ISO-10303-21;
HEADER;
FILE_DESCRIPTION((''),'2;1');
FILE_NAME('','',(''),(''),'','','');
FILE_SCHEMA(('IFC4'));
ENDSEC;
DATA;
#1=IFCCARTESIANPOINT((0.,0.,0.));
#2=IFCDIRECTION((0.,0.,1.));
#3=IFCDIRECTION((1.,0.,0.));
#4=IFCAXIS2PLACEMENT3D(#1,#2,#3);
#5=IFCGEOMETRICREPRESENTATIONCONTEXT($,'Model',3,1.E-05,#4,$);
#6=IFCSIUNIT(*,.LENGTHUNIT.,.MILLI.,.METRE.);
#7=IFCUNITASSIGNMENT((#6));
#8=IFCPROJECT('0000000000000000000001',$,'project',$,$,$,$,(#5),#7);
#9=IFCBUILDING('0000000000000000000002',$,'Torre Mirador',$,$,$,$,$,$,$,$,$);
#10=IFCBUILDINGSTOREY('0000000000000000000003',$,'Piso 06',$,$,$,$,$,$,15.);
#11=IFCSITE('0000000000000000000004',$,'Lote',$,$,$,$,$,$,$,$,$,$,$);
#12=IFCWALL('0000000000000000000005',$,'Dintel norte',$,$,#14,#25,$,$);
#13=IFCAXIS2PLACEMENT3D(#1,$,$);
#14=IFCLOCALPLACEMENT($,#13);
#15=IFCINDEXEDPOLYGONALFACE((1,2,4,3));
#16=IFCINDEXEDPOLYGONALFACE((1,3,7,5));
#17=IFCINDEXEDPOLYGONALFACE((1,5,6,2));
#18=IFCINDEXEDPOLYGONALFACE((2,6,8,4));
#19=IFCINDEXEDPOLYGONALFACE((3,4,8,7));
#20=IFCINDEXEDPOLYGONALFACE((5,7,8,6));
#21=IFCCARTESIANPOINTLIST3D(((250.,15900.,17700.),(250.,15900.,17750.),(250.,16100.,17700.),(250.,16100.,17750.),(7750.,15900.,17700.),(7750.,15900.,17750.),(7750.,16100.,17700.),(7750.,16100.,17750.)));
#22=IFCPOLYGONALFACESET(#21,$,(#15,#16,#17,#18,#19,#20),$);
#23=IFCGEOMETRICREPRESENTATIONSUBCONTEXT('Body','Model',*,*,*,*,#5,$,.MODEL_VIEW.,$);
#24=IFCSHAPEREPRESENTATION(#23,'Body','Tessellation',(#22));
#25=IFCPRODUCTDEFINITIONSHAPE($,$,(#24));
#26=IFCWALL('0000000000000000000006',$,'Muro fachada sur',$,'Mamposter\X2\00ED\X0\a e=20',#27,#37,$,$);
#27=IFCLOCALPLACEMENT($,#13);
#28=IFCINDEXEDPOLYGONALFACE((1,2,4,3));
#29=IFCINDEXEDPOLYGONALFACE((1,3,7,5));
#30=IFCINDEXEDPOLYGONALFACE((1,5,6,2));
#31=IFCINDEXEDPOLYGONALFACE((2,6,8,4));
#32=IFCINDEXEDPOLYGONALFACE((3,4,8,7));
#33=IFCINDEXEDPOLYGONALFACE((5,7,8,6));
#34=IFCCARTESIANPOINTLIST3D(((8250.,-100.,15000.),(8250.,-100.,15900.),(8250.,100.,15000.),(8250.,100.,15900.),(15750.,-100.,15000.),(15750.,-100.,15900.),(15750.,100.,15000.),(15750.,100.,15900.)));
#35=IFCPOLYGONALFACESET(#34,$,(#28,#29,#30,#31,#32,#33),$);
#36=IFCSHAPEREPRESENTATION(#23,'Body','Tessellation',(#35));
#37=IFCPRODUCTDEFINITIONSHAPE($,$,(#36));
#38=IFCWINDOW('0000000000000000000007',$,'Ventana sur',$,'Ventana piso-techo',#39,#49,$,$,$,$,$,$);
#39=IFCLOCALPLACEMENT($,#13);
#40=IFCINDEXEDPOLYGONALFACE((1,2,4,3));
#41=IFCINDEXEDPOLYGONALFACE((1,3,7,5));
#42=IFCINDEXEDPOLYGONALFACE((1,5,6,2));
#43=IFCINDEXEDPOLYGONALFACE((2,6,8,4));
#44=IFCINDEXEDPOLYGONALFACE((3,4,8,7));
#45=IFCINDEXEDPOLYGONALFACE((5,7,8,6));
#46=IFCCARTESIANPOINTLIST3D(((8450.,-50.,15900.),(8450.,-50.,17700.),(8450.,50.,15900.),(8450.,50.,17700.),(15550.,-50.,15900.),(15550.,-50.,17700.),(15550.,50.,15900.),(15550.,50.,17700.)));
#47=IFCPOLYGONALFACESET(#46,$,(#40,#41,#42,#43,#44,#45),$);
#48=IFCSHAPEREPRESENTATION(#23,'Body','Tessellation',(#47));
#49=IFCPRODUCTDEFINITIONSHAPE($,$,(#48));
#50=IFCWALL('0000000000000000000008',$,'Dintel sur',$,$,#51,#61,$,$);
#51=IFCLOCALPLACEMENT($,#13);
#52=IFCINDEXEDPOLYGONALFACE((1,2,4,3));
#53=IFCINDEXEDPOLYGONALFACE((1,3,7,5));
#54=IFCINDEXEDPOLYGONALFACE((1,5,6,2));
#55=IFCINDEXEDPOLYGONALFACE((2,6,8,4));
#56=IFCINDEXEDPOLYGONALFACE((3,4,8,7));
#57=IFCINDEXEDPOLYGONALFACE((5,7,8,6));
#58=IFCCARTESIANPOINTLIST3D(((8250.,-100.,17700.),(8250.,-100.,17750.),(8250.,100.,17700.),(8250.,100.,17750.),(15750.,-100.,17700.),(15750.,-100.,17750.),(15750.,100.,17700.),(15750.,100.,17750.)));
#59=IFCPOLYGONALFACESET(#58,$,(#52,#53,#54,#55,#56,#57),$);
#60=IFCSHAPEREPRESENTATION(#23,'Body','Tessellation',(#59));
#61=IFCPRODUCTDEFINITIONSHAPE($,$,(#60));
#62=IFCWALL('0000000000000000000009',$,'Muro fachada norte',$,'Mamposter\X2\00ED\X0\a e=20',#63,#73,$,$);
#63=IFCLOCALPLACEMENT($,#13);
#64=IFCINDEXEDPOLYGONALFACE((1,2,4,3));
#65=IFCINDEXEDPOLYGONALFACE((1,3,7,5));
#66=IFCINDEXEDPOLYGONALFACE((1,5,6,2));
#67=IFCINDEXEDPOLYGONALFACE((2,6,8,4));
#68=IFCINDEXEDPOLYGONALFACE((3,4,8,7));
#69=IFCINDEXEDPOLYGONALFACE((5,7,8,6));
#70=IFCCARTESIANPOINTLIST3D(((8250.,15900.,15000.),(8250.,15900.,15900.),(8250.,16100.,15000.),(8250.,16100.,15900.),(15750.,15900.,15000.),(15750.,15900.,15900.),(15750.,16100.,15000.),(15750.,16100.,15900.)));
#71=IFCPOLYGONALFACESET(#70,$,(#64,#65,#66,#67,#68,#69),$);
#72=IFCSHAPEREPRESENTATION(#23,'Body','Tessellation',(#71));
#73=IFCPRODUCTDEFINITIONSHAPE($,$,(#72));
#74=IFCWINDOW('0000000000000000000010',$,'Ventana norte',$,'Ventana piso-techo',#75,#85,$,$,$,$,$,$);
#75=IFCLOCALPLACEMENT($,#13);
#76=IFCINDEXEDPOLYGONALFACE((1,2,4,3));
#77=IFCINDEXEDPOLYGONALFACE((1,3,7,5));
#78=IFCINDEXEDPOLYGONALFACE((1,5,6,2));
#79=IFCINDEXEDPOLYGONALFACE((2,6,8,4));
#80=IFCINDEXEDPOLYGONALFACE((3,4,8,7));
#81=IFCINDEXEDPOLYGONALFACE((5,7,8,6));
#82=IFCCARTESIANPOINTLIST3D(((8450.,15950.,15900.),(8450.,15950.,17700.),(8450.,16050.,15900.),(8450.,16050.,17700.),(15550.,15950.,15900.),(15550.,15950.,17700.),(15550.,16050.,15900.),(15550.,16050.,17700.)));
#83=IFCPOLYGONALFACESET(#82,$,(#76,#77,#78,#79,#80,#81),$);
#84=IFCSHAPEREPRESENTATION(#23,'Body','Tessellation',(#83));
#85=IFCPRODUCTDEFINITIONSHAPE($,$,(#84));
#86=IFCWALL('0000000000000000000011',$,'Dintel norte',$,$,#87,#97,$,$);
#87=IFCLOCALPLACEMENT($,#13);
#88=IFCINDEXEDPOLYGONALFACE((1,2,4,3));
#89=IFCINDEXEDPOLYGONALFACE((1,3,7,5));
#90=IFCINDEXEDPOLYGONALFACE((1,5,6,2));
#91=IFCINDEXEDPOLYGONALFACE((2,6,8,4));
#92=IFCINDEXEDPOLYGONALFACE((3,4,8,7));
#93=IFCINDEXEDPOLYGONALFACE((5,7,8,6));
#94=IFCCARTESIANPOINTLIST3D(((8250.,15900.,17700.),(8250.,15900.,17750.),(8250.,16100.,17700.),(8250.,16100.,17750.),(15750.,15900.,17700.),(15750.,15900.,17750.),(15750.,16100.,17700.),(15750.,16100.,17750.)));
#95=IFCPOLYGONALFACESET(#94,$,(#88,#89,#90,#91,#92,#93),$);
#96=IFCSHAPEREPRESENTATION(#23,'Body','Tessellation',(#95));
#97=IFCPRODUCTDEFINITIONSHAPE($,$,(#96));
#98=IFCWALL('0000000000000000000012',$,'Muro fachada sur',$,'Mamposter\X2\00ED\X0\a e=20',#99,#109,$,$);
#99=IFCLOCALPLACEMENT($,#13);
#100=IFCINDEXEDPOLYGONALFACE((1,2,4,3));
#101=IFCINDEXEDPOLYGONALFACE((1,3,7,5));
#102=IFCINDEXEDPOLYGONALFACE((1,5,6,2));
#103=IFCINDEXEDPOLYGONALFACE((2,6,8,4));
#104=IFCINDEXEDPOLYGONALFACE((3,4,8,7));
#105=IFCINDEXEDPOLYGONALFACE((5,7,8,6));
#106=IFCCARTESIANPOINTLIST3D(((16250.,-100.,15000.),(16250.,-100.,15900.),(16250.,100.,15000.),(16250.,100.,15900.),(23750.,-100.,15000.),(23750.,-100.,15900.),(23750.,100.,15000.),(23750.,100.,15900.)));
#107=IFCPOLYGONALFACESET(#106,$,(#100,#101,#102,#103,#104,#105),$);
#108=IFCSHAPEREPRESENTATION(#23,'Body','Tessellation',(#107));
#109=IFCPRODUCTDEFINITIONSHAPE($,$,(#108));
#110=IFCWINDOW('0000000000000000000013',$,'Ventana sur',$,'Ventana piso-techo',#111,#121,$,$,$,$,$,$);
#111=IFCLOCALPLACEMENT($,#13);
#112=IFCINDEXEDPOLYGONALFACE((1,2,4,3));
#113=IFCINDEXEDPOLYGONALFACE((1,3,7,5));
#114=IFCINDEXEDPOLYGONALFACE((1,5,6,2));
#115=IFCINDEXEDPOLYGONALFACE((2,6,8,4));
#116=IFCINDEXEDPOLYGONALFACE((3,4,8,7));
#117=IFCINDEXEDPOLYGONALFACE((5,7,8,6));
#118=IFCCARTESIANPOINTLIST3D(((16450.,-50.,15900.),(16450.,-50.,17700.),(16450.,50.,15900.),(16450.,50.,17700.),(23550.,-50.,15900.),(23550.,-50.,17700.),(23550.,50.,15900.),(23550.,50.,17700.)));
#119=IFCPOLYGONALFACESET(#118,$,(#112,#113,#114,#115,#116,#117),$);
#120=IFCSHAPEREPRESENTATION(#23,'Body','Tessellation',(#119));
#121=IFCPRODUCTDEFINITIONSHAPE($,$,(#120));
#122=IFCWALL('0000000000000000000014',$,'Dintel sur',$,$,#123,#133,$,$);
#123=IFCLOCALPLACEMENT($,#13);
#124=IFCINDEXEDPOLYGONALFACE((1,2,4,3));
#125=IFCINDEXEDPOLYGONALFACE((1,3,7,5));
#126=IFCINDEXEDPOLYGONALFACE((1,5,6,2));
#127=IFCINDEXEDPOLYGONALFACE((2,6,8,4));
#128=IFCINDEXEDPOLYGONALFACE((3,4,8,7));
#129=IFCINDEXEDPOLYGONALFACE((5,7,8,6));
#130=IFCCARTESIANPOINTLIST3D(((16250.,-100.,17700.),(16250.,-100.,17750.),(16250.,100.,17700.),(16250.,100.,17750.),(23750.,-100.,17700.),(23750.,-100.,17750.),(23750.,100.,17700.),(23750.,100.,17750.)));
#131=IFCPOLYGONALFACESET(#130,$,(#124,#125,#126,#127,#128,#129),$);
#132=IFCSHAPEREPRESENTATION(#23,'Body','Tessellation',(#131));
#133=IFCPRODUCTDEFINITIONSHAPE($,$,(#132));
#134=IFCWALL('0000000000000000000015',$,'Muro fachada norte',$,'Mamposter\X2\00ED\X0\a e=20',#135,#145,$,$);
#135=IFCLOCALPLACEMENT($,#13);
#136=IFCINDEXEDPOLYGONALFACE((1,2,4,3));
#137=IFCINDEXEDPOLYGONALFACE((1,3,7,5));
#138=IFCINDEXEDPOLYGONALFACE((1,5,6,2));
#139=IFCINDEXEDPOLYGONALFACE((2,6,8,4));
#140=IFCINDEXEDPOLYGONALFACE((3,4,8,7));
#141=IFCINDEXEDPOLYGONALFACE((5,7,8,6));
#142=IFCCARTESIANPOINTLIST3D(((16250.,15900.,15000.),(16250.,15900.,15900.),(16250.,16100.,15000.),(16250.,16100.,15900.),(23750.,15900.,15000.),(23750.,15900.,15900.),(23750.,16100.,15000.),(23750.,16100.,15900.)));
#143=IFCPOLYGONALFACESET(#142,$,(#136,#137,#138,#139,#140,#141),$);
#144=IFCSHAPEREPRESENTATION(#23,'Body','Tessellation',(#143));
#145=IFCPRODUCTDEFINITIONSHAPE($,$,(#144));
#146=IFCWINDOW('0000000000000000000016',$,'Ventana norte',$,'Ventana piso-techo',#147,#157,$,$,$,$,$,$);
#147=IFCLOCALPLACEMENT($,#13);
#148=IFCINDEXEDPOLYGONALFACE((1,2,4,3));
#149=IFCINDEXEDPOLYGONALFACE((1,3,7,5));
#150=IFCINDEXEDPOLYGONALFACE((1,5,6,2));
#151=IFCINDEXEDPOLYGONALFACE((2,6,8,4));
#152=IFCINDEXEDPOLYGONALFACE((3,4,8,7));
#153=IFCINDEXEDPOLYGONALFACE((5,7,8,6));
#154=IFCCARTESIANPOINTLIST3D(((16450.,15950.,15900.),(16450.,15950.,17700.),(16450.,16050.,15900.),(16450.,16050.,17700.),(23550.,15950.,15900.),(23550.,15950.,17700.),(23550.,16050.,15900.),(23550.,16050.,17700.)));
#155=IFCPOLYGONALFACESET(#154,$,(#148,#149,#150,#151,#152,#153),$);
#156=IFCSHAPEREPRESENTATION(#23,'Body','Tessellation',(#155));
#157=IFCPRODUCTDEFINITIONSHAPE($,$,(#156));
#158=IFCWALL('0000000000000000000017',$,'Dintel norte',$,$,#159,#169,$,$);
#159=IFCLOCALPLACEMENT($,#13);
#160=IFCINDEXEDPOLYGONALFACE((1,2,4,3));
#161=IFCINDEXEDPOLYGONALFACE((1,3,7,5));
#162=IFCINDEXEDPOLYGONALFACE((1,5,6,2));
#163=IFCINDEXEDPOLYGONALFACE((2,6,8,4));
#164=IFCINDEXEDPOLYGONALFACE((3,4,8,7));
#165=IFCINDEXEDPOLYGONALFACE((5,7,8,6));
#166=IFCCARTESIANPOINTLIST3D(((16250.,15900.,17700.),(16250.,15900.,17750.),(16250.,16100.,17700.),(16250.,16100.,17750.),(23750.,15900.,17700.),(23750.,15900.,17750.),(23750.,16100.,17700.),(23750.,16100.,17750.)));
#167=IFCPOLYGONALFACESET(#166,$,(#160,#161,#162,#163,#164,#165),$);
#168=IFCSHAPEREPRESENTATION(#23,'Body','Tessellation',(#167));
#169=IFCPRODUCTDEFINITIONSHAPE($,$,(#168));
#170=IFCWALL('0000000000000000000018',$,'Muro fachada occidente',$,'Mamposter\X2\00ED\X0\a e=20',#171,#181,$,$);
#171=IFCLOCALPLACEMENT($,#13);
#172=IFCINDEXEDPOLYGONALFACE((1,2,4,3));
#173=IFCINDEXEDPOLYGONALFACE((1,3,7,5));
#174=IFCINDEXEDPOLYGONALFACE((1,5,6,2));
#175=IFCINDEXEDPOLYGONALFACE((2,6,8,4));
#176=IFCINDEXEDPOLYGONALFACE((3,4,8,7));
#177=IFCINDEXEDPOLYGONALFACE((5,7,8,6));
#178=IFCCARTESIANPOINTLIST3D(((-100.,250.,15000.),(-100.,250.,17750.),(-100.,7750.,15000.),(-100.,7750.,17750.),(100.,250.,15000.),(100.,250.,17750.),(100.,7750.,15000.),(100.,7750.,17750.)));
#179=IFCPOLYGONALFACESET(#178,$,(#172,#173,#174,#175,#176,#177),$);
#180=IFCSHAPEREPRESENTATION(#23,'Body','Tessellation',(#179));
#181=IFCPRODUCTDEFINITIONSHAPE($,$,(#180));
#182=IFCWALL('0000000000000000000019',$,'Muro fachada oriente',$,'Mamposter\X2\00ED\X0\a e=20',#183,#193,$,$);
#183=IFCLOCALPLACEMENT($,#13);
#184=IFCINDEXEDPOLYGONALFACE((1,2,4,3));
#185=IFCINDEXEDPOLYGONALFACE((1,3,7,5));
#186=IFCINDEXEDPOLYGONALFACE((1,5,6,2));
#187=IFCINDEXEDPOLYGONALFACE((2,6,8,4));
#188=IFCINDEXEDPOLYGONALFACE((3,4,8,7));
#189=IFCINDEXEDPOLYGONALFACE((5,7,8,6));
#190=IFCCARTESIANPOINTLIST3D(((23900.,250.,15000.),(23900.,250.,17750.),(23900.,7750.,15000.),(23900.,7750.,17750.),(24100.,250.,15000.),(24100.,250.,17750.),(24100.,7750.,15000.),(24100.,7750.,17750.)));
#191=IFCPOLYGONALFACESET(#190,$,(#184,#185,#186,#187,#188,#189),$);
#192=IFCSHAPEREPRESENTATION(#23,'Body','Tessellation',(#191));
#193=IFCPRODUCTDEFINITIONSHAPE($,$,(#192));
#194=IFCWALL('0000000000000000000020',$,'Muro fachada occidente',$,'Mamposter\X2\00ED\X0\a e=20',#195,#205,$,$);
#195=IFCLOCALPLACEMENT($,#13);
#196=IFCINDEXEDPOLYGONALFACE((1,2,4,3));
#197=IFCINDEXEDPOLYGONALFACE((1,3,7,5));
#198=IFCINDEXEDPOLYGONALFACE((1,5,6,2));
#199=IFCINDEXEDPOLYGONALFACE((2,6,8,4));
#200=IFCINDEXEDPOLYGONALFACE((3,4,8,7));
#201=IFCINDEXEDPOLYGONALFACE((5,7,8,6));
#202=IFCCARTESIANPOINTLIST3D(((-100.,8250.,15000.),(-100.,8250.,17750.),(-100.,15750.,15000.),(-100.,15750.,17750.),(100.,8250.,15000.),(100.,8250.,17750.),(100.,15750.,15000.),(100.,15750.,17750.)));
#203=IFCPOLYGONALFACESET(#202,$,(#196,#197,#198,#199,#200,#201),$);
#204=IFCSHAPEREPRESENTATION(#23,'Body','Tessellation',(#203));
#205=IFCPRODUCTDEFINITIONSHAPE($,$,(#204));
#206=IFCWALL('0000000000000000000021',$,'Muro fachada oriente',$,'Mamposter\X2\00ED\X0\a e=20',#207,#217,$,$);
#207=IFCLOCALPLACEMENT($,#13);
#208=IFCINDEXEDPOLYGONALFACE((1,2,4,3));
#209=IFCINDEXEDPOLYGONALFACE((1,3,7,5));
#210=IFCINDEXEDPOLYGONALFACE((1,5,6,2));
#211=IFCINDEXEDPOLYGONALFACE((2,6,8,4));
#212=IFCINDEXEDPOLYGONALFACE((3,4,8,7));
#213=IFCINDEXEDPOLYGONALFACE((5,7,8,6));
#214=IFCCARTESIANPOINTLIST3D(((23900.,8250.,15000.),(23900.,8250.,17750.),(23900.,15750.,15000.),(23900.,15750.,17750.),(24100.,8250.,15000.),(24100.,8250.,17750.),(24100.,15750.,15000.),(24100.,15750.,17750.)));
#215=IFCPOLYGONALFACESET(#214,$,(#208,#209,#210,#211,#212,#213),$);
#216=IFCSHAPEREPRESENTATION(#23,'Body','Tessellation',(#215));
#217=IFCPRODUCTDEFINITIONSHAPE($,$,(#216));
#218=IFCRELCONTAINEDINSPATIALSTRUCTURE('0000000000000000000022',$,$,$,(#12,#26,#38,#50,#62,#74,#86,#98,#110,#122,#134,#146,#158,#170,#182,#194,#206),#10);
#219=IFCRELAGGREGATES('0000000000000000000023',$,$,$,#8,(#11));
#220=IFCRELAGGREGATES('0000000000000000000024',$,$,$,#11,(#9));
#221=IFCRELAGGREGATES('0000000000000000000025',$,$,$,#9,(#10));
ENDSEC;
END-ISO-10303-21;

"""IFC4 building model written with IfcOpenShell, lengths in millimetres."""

from ifc_helpers import new_model, si_unit, frame, origin_with_axes, place, context, subcontext, project, spatial, indexed_curve, outline, extrude, element, save


model = new_model("IFC4")

# Units and contexts
model_context = context("Model", 3, precision=1e-05, world=origin_with_axes())
body_context = subcontext(model_context, "Body", "Model", "MODEL_VIEW")
ifc_project = project(units=[si_unit("LENGTHUNIT", "METRE", prefix="MILLI")], contexts=[model_context])

# Site, building, storey
site = spatial("IfcSite", under=ifc_project, Name="Lote")
building = spatial("IfcBuilding", under=site, Name="Torre Mirador")
storey = spatial("IfcBuildingStorey", under=building, Name="Piso 06", Elevation=15.0)

# Walls
wall_1_placement = place(None, frame((250.0, 15900.0, 17700.0), z_axis=(0.0, 0.0, 1.0), x_axis=(1.0, 0.0, 0.0)))
element("IfcWall", 1, at=wall_1_placement, inside=storey, Name="Dintel norte", context=body_context, shape_type="SweptSolid", body=[
    extrude(outline(indexed_curve([(0.0, 0.0), (0.0, 200.0), (7500.0, 200.0), (7500.0, 0.0), (0.0, 0.0)], self_intersect=False)), origin_with_axes(), (0.0, 0.0, 1.0), 50.0),
])
wall_2_placement = place(None, frame((8250.0, -100.0, 15000.0), z_axis=(0.0, 0.0, 1.0), x_axis=(1.0, 0.0, 0.0)))
element("IfcWall", 2, at=wall_2_placement, inside=storey, Name="Muro fachada sur", ObjectType="Mampostería e=20", context=body_context, shape_type="SweptSolid", body=[
    extrude(outline(indexed_curve([(0.0, 0.0), (0.0, 200.0), (7500.0, 200.0), (7500.0, 0.0), (0.0, 0.0)], self_intersect=False)), origin_with_axes(), (0.0, 0.0, 1.0), 900.0),
])

# Window
window_1_placement = place(None, frame((8450.0, -50.0, 15900.0), z_axis=(0.0, 0.0, 1.0), x_axis=(1.0, 0.0, 0.0)))
element("IfcWindow", 3, at=window_1_placement, inside=storey, Name="Ventana sur", ObjectType="Ventana piso-techo", context=body_context, shape_type="SweptSolid", body=[
    extrude(outline(indexed_curve([(0.0, 0.0), (0.0, 100.0), (7100.0, 100.0), (7100.0, 0.0), (0.0, 0.0)], self_intersect=False)), origin_with_axes(), (0.0, 0.0, 1.0), 1800.0),
])

# Walls
wall_3_placement = place(None, frame((8250.0, -100.0, 17700.0), z_axis=(0.0, 0.0, 1.0), x_axis=(1.0, 0.0, 0.0)))
element("IfcWall", 4, at=wall_3_placement, inside=storey, Name="Dintel sur", context=body_context, shape_type="SweptSolid", body=[
    extrude(outline(indexed_curve([(0.0, 0.0), (0.0, 200.0), (7500.0, 200.0), (7500.0, 0.0), (0.0, 0.0)], self_intersect=False)), origin_with_axes(), (0.0, 0.0, 1.0), 50.0),
])
wall_4_placement = place(None, frame((8250.0, 15900.0, 15000.0), z_axis=(0.0, 0.0, 1.0), x_axis=(1.0, 0.0, 0.0)))
element("IfcWall", 5, at=wall_4_placement, inside=storey, Name="Muro fachada norte", ObjectType="Mampostería e=20", context=body_context, shape_type="SweptSolid", body=[
    extrude(outline(indexed_curve([(0.0, 0.0), (0.0, 200.0), (7500.0, 200.0), (7500.0, 0.0), (0.0, 0.0)], self_intersect=False)), origin_with_axes(), (0.0, 0.0, 1.0), 900.0),
])

# Window
window_2_placement = place(None, frame((8450.0, 15950.0, 15900.0), z_axis=(0.0, 0.0, 1.0), x_axis=(1.0, 0.0, 0.0)))
element("IfcWindow", 6, at=window_2_placement, inside=storey, Name="Ventana norte", ObjectType="Ventana piso-techo", context=body_context, shape_type="SweptSolid", body=[
    extrude(outline(indexed_curve([(0.0, 0.0), (0.0, 100.0), (7100.0, 100.0), (7100.0, 0.0), (0.0, 0.0)], self_intersect=False)), origin_with_axes(), (0.0, 0.0, 1.0), 1800.0),
])

# Walls
wall_5_placement = place(None, frame((8250.0, 15900.0, 17700.0), z_axis=(0.0, 0.0, 1.0), x_axis=(1.0, 0.0, 0.0)))
element("IfcWall", 7, at=wall_5_placement, inside=storey, Name="Dintel norte", context=body_context, shape_type="SweptSolid", body=[
    extrude(outline(indexed_curve([(0.0, 0.0), (0.0, 200.0), (7500.0, 200.0), (7500.0, 0.0), (0.0, 0.0)], self_intersect=False)), origin_with_axes(), (0.0, 0.0, 1.0), 50.0),
])
wall_6_placement = place(None, frame((16250.0, -100.0, 15000.0), z_axis=(0.0, 0.0, 1.0), x_axis=(1.0, 0.0, 0.0)))
element("IfcWall", 8, at=wall_6_placement, inside=storey, Name="Muro fachada sur", ObjectType="Mampostería e=20", context=body_context, shape_type="SweptSolid", body=[
    extrude(outline(indexed_curve([(0.0, 0.0), (0.0, 200.0), (7500.0, 200.0), (7500.0, 0.0), (0.0, 0.0)], self_intersect=False)), origin_with_axes(), (0.0, 0.0, 1.0), 900.0),
])

# Window
window_3_placement = place(None, frame((16450.0, -50.0, 15900.0), z_axis=(0.0, 0.0, 1.0), x_axis=(1.0, 0.0, 0.0)))
element("IfcWindow", 9, at=window_3_placement, inside=storey, Name="Ventana sur", ObjectType="Ventana piso-techo", context=body_context, shape_type="SweptSolid", body=[
    extrude(outline(indexed_curve([(0.0, 0.0), (0.0, 100.0), (7100.0, 100.0), (7100.0, 0.0), (0.0, 0.0)], self_intersect=False)), origin_with_axes(), (0.0, 0.0, 1.0), 1800.0),
])

# Walls
wall_7_placement = place(None, frame((16250.0, -100.0, 17700.0), z_axis=(0.0, 0.0, 1.0), x_axis=(1.0, 0.0, 0.0)))
element("IfcWall", 10, at=wall_7_placement, inside=storey, Name="Dintel sur", context=body_context, shape_type="SweptSolid", body=[
    extrude(outline(indexed_curve([(0.0, 0.0), (0.0, 200.0), (7500.0, 200.0), (7500.0, 0.0), (0.0, 0.0)], self_intersect=False)), origin_with_axes(), (0.0, 0.0, 1.0), 50.0),
])
wall_8_placement = place(None, frame((16250.0, 15900.0, 15000.0), z_axis=(0.0, 0.0, 1.0), x_axis=(1.0, 0.0, 0.0)))
element("IfcWall", 11, at=wall_8_placement, inside=storey, Name="Muro fachada norte", ObjectType="Mampostería e=20", context=body_context, shape_type="SweptSolid", body=[
    extrude(outline(indexed_curve([(0.0, 0.0), (0.0, 200.0), (7500.0, 200.0), (7500.0, 0.0), (0.0, 0.0)], self_intersect=False)), origin_with_axes(), (0.0, 0.0, 1.0), 900.0),
])

# Window
window_4_placement = place(None, frame((16450.0, 15950.0, 15900.0), z_axis=(0.0, 0.0, 1.0), x_axis=(1.0, 0.0, 0.0)))
element("IfcWindow", 12, at=window_4_placement, inside=storey, Name="Ventana norte", ObjectType="Ventana piso-techo", context=body_context, shape_type="SweptSolid", body=[
    extrude(outline(indexed_curve([(0.0, 0.0), (0.0, 100.0), (7100.0, 100.0), (7100.0, 0.0), (0.0, 0.0)], self_intersect=False)), origin_with_axes(), (0.0, 0.0, 1.0), 1800.0),
])

# Walls
wall_9_placement = place(None, frame((16250.0, 15900.0, 17700.0), z_axis=(0.0, 0.0, 1.0), x_axis=(1.0, 0.0, 0.0)))
element("IfcWall", 13, at=wall_9_placement, inside=storey, Name="Dintel norte", context=body_context, shape_type="SweptSolid", body=[
    extrude(outline(indexed_curve([(0.0, 0.0), (0.0, 200.0), (7500.0, 200.0), (7500.0, 0.0), (0.0, 0.0)], self_intersect=False)), origin_with_axes(), (0.0, 0.0, 1.0), 50.0),
])
for number, where, z_axis, x_axis, name in (
    (14, (-100.0, 250.0, 15000.0), (0.0, 0.0, 1.0), (1.0, 0.0, 0.0), "Muro fachada occidente"),
    (15, (23900.0, 250.0, 15000.0), (0.0, 0.0, 1.0), (1.0, 0.0, 0.0), "Muro fachada oriente"),
    (16, (-100.0, 8250.0, 15000.0), (0.0, 0.0, 1.0), (1.0, 0.0, 0.0), "Muro fachada occidente"),
    (17, (23900.0, 8250.0, 15000.0), (0.0, 0.0, 1.0), (1.0, 0.0, 0.0), "Muro fachada oriente"),
):
    element("IfcWall", number, at=place(None, frame(where, z_axis=z_axis, x_axis=x_axis)), inside=storey, Name=name, ObjectType="Mampostería e=20", context=body_context, shape_type="SweptSolid", body=[
        extrude(outline(indexed_curve([(0.0, 0.0), (0.0, 7500.0), (200.0, 7500.0), (200.0, 0.0), (0.0, 0.0)], self_intersect=False)), origin_with_axes(), (0.0, 0.0, 1.0), 2750.0),
    ])

save(model, "model.ifc")
